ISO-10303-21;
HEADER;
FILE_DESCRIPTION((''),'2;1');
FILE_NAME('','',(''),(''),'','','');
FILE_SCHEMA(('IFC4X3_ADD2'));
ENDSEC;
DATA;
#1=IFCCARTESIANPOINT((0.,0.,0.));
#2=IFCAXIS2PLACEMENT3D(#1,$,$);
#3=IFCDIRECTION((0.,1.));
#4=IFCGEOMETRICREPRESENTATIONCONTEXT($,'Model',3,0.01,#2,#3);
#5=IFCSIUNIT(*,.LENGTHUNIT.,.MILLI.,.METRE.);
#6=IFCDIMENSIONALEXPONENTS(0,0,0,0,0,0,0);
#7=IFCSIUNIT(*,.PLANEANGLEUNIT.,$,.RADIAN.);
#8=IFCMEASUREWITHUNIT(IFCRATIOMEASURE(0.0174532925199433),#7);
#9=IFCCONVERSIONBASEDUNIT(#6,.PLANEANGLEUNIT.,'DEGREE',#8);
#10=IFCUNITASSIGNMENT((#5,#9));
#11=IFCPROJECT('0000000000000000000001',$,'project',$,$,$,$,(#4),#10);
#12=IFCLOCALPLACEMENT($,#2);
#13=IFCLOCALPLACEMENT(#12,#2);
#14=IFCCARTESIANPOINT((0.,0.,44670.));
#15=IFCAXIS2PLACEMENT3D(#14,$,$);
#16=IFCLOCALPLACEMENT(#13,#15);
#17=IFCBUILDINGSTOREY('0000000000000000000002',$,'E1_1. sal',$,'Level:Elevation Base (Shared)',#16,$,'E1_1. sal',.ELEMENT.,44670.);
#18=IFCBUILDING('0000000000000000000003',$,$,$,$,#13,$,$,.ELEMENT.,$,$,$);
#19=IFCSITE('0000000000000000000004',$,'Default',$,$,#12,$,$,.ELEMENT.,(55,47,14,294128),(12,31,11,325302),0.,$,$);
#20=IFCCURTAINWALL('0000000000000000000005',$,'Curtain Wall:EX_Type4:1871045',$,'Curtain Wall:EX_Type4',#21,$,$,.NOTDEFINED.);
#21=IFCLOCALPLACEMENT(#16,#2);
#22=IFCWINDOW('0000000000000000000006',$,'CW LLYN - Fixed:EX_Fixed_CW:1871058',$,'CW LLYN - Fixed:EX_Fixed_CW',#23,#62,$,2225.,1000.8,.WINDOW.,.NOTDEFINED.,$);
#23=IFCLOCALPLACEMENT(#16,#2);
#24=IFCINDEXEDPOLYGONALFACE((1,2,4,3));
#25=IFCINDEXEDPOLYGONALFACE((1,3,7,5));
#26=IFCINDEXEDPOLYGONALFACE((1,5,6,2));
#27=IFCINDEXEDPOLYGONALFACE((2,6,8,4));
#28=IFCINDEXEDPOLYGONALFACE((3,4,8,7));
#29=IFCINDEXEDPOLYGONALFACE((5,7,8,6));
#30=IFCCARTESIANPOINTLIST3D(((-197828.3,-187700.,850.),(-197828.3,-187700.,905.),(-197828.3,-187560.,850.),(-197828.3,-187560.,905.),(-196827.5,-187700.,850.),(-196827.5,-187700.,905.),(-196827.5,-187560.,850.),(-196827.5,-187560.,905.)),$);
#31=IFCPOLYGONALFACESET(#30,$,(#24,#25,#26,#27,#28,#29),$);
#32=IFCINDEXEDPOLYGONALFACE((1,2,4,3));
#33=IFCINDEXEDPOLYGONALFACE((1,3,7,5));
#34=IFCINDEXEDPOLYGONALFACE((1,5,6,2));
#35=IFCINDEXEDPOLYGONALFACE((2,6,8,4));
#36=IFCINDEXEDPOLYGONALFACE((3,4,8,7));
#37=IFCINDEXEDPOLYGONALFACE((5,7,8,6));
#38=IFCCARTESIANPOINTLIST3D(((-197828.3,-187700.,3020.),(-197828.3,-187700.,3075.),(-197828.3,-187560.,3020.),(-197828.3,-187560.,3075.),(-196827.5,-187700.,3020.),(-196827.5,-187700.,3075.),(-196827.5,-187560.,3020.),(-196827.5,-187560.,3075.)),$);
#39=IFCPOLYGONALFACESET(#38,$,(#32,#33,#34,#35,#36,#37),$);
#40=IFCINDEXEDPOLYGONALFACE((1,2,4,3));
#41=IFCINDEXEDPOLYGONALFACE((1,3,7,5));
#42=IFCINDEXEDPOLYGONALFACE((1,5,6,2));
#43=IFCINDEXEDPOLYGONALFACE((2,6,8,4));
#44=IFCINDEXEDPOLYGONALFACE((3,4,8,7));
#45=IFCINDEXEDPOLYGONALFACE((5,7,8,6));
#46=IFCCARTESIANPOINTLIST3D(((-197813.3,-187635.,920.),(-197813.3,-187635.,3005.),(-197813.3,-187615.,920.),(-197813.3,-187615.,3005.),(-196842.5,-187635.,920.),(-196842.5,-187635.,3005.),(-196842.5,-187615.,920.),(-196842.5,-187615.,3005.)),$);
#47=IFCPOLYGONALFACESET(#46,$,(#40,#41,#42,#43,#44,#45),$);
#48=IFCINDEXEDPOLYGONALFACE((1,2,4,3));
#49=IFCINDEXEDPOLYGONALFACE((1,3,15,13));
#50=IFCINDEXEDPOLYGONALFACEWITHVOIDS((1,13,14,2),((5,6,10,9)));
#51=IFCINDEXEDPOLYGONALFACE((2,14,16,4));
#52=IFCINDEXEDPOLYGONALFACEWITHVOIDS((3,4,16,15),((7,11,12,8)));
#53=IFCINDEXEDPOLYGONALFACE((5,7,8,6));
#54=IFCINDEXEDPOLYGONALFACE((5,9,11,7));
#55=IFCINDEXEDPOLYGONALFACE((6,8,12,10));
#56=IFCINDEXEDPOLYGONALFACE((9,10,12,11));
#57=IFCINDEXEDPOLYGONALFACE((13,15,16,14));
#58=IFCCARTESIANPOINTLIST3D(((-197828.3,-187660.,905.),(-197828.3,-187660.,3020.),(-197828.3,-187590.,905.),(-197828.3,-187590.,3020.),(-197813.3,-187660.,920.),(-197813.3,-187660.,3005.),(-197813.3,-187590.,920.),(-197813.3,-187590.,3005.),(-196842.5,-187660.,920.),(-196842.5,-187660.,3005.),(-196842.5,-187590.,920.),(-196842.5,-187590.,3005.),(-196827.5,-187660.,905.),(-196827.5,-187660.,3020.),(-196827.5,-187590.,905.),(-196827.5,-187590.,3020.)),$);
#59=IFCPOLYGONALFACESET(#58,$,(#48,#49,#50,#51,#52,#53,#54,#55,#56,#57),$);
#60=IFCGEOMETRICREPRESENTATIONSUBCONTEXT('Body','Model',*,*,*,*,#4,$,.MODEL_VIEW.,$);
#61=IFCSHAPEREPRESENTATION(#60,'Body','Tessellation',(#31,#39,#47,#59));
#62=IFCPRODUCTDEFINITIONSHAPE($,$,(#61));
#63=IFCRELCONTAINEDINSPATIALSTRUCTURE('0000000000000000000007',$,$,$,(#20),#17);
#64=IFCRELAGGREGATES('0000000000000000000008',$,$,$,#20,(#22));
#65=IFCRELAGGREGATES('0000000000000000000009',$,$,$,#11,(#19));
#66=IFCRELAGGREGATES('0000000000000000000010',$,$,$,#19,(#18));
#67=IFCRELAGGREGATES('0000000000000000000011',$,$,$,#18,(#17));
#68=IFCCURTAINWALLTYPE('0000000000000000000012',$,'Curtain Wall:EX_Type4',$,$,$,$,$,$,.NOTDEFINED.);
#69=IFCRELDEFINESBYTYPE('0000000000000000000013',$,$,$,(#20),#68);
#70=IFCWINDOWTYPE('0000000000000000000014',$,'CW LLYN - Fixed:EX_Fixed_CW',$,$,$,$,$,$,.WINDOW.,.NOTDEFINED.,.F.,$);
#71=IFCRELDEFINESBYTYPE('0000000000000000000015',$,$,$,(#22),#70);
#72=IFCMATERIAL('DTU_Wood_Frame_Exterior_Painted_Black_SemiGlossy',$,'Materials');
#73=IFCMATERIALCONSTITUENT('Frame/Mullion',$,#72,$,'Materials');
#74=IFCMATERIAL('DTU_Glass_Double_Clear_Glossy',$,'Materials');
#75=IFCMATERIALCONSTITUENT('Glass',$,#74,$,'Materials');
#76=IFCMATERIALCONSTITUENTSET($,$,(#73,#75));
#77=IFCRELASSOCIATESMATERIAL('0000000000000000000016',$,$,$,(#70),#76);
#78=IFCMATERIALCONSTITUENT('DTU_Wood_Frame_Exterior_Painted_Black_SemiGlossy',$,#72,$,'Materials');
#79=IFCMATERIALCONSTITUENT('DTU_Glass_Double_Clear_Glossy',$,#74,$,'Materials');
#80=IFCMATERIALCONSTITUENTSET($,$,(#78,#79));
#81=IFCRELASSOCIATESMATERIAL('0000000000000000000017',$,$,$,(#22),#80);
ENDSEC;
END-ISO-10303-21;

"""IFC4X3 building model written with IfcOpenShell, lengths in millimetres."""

from ifc_helpers import new_model, entity, si_unit, converted_unit, direction, frame, frame_2d, origin, place, context, subcontext, project, spatial, polyline, rectangle, outline, extrude, source, transform, mapped, material, constituent, constituent_set, type_object, type_shapes, element, aggregate, save


model = new_model("IFC4X3")

# Units and contexts
model_context = context("Model", 3, precision=0.01, world=origin(), true_north=direction((0.0, 1.0)))
body_context = subcontext(model_context, "Body", "Model", "MODEL_VIEW")
ifc_project = project(units=[si_unit("LENGTHUNIT", "METRE", prefix="MILLI"), converted_unit("PLANEANGLEUNIT", "DEGREE", entity("IfcRatioMeasure", 0.0174532925199433), si_unit("PLANEANGLEUNIT", "RADIAN"), dimensions=[0, 0, 0, 0, 0, 0, 0])], contexts=[model_context])

# Site, building, storey
site_placement = place(None, origin())
site = spatial("IfcSite", under=ifc_project, at=site_placement, Name="Default", CompositionType="ELEMENT", RefLatitude=(55, 47, 14, 294128), RefLongitude=(12, 31, 11, 325302), RefElevation=0.0)
building_placement = place(site_placement, origin())
building = spatial("IfcBuilding", under=site, at=building_placement, CompositionType="ELEMENT")
storey_placement = place(building_placement, frame((0.0, 0.0, 44670.0)))
storey = spatial("IfcBuildingStorey", under=building, at=storey_placement, Name="E1_1. sal", ObjectType="Level:Elevation Base (Shared)", LongName="E1_1. sal", CompositionType="ELEMENT", Elevation=44670.0)

# Curtain wall
curtain_wall_type_1 = type_object("IfcCurtainWallType", Name="Curtain Wall:EX_Type4", PredefinedType="NOTDEFINED")
curtain_wall_1_placement = place(storey_placement, frame((0.0, 0.0, -44670.0)))
curtain_wall_1 = element("IfcCurtainWall", 1, at=curtain_wall_1_placement, inside=storey, type_object=curtain_wall_type_1, Name="Curtain Wall:EX_Type4:1871045", ObjectType="Curtain Wall:EX_Type4", PredefinedType="NOTDEFINED")

# Window
ifc_material_1 = material(Name="DTU_Wood_Frame_Exterior_Painted_Black_SemiGlossy", Category="Materials")
ifc_material_2 = material(Name="DTU_Glass_Double_Clear_Glossy", Category="Materials")
ifc_constituent_1 = constituent(ifc_material_1, Name="DTU_Wood_Frame_Exterior_Painted_Black_SemiGlossy", Category="Materials")
ifc_constituent_2 = constituent(ifc_material_2, Name="DTU_Glass_Double_Clear_Glossy", Category="Materials")
ifc_constituent_set_1 = constituent_set(constituents=[ifc_constituent_1, ifc_constituent_2])
ifc_constituent_3 = constituent(ifc_material_1, Name="Frame/Mullion", Category="Materials")
ifc_constituent_4 = constituent(ifc_material_2, Name="Glass", Category="Materials")
ifc_constituent_set_2 = constituent_set(constituents=[ifc_constituent_3, ifc_constituent_4])
window_type_1 = type_object("IfcWindowType", Name="CW LLYN - Fixed:EX_Fixed_CW", ParameterTakesPrecedence=False, PartitioningType="NOTDEFINED", PredefinedType="WINDOW", material=ifc_constituent_set_2)
shared_shape_1 = source(origin(), body_context, "Body", "SweptSolid", [
    extrude(rectangle(XDim=140.0, YDim=1000.8, at=frame_2d((0.0, 0.0), x_axis=(1.0, 0.0))), frame((0.0, -130.0, 0.0), z_axis=(0.0, 0.0, 1.0), x_axis=(0.0, -1.0, 0.0)), (0.0, 0.0, 1.0), 55.0),
    extrude(rectangle(XDim=140.0, YDim=1000.8, at=frame_2d((0.0, 0.0), x_axis=(1.0, 0.0))), frame((0.0, -130.0, 2170.0), z_axis=(0.0, 0.0, 1.0), x_axis=(0.0, -1.0, 0.0)), (0.0, 0.0, 1.0), 55.0),
    extrude(rectangle(XDim=970.8, YDim=20.0, at=frame_2d((0.0, 0.0), x_axis=(1.0, 0.0))), frame((0.0, -125.0, 70.0), z_axis=(0.0, 0.0, 1.0), x_axis=(-1.0, 0.0, 0.0)), (0.0, 0.0, 1.0), 2085.0),
    extrude(outline(polyline([(-1057.5, -500.4), (1057.5, -500.4), (1057.5, 500.4), (-1057.5, 500.4), (-1057.5, -500.4)]), holes=[polyline([(-1042.5, 485.4), (1042.5, 485.4), (1042.5, -485.4), (-1042.5, -485.4), (-1042.5, 485.4)])]), frame((0.0, -90.0, 1112.5), z_axis=(0.0, -1.0, 0.0), x_axis=(0.0, 0.0, 1.0)), (0.0, 0.0, 1.0), 70.0),
])
type_shapes(window_type_1, [shared_shape_1])
window_1_placement = place(curtain_wall_1_placement, frame((-197327.9, -187500.0, 45520.0)))
window_1 = element("IfcWindow", 2, at=window_1_placement, type_object=window_type_1, material=ifc_constituent_set_1, Name="CW LLYN - Fixed:EX_Fixed_CW:1871058", ObjectType="CW LLYN - Fixed:EX_Fixed_CW", OverallHeight=2225.0, OverallWidth=1000.8, PartitioningType="NOTDEFINED", PredefinedType="WINDOW", context=body_context, shape_type="MappedRepresentation", body=[
    mapped(shared_shape_1, transform((0.0, 0.0, 0.0), scale=1.0)),
])

aggregate(curtain_wall_1, [window_1])

save(model, "model.ifc")
